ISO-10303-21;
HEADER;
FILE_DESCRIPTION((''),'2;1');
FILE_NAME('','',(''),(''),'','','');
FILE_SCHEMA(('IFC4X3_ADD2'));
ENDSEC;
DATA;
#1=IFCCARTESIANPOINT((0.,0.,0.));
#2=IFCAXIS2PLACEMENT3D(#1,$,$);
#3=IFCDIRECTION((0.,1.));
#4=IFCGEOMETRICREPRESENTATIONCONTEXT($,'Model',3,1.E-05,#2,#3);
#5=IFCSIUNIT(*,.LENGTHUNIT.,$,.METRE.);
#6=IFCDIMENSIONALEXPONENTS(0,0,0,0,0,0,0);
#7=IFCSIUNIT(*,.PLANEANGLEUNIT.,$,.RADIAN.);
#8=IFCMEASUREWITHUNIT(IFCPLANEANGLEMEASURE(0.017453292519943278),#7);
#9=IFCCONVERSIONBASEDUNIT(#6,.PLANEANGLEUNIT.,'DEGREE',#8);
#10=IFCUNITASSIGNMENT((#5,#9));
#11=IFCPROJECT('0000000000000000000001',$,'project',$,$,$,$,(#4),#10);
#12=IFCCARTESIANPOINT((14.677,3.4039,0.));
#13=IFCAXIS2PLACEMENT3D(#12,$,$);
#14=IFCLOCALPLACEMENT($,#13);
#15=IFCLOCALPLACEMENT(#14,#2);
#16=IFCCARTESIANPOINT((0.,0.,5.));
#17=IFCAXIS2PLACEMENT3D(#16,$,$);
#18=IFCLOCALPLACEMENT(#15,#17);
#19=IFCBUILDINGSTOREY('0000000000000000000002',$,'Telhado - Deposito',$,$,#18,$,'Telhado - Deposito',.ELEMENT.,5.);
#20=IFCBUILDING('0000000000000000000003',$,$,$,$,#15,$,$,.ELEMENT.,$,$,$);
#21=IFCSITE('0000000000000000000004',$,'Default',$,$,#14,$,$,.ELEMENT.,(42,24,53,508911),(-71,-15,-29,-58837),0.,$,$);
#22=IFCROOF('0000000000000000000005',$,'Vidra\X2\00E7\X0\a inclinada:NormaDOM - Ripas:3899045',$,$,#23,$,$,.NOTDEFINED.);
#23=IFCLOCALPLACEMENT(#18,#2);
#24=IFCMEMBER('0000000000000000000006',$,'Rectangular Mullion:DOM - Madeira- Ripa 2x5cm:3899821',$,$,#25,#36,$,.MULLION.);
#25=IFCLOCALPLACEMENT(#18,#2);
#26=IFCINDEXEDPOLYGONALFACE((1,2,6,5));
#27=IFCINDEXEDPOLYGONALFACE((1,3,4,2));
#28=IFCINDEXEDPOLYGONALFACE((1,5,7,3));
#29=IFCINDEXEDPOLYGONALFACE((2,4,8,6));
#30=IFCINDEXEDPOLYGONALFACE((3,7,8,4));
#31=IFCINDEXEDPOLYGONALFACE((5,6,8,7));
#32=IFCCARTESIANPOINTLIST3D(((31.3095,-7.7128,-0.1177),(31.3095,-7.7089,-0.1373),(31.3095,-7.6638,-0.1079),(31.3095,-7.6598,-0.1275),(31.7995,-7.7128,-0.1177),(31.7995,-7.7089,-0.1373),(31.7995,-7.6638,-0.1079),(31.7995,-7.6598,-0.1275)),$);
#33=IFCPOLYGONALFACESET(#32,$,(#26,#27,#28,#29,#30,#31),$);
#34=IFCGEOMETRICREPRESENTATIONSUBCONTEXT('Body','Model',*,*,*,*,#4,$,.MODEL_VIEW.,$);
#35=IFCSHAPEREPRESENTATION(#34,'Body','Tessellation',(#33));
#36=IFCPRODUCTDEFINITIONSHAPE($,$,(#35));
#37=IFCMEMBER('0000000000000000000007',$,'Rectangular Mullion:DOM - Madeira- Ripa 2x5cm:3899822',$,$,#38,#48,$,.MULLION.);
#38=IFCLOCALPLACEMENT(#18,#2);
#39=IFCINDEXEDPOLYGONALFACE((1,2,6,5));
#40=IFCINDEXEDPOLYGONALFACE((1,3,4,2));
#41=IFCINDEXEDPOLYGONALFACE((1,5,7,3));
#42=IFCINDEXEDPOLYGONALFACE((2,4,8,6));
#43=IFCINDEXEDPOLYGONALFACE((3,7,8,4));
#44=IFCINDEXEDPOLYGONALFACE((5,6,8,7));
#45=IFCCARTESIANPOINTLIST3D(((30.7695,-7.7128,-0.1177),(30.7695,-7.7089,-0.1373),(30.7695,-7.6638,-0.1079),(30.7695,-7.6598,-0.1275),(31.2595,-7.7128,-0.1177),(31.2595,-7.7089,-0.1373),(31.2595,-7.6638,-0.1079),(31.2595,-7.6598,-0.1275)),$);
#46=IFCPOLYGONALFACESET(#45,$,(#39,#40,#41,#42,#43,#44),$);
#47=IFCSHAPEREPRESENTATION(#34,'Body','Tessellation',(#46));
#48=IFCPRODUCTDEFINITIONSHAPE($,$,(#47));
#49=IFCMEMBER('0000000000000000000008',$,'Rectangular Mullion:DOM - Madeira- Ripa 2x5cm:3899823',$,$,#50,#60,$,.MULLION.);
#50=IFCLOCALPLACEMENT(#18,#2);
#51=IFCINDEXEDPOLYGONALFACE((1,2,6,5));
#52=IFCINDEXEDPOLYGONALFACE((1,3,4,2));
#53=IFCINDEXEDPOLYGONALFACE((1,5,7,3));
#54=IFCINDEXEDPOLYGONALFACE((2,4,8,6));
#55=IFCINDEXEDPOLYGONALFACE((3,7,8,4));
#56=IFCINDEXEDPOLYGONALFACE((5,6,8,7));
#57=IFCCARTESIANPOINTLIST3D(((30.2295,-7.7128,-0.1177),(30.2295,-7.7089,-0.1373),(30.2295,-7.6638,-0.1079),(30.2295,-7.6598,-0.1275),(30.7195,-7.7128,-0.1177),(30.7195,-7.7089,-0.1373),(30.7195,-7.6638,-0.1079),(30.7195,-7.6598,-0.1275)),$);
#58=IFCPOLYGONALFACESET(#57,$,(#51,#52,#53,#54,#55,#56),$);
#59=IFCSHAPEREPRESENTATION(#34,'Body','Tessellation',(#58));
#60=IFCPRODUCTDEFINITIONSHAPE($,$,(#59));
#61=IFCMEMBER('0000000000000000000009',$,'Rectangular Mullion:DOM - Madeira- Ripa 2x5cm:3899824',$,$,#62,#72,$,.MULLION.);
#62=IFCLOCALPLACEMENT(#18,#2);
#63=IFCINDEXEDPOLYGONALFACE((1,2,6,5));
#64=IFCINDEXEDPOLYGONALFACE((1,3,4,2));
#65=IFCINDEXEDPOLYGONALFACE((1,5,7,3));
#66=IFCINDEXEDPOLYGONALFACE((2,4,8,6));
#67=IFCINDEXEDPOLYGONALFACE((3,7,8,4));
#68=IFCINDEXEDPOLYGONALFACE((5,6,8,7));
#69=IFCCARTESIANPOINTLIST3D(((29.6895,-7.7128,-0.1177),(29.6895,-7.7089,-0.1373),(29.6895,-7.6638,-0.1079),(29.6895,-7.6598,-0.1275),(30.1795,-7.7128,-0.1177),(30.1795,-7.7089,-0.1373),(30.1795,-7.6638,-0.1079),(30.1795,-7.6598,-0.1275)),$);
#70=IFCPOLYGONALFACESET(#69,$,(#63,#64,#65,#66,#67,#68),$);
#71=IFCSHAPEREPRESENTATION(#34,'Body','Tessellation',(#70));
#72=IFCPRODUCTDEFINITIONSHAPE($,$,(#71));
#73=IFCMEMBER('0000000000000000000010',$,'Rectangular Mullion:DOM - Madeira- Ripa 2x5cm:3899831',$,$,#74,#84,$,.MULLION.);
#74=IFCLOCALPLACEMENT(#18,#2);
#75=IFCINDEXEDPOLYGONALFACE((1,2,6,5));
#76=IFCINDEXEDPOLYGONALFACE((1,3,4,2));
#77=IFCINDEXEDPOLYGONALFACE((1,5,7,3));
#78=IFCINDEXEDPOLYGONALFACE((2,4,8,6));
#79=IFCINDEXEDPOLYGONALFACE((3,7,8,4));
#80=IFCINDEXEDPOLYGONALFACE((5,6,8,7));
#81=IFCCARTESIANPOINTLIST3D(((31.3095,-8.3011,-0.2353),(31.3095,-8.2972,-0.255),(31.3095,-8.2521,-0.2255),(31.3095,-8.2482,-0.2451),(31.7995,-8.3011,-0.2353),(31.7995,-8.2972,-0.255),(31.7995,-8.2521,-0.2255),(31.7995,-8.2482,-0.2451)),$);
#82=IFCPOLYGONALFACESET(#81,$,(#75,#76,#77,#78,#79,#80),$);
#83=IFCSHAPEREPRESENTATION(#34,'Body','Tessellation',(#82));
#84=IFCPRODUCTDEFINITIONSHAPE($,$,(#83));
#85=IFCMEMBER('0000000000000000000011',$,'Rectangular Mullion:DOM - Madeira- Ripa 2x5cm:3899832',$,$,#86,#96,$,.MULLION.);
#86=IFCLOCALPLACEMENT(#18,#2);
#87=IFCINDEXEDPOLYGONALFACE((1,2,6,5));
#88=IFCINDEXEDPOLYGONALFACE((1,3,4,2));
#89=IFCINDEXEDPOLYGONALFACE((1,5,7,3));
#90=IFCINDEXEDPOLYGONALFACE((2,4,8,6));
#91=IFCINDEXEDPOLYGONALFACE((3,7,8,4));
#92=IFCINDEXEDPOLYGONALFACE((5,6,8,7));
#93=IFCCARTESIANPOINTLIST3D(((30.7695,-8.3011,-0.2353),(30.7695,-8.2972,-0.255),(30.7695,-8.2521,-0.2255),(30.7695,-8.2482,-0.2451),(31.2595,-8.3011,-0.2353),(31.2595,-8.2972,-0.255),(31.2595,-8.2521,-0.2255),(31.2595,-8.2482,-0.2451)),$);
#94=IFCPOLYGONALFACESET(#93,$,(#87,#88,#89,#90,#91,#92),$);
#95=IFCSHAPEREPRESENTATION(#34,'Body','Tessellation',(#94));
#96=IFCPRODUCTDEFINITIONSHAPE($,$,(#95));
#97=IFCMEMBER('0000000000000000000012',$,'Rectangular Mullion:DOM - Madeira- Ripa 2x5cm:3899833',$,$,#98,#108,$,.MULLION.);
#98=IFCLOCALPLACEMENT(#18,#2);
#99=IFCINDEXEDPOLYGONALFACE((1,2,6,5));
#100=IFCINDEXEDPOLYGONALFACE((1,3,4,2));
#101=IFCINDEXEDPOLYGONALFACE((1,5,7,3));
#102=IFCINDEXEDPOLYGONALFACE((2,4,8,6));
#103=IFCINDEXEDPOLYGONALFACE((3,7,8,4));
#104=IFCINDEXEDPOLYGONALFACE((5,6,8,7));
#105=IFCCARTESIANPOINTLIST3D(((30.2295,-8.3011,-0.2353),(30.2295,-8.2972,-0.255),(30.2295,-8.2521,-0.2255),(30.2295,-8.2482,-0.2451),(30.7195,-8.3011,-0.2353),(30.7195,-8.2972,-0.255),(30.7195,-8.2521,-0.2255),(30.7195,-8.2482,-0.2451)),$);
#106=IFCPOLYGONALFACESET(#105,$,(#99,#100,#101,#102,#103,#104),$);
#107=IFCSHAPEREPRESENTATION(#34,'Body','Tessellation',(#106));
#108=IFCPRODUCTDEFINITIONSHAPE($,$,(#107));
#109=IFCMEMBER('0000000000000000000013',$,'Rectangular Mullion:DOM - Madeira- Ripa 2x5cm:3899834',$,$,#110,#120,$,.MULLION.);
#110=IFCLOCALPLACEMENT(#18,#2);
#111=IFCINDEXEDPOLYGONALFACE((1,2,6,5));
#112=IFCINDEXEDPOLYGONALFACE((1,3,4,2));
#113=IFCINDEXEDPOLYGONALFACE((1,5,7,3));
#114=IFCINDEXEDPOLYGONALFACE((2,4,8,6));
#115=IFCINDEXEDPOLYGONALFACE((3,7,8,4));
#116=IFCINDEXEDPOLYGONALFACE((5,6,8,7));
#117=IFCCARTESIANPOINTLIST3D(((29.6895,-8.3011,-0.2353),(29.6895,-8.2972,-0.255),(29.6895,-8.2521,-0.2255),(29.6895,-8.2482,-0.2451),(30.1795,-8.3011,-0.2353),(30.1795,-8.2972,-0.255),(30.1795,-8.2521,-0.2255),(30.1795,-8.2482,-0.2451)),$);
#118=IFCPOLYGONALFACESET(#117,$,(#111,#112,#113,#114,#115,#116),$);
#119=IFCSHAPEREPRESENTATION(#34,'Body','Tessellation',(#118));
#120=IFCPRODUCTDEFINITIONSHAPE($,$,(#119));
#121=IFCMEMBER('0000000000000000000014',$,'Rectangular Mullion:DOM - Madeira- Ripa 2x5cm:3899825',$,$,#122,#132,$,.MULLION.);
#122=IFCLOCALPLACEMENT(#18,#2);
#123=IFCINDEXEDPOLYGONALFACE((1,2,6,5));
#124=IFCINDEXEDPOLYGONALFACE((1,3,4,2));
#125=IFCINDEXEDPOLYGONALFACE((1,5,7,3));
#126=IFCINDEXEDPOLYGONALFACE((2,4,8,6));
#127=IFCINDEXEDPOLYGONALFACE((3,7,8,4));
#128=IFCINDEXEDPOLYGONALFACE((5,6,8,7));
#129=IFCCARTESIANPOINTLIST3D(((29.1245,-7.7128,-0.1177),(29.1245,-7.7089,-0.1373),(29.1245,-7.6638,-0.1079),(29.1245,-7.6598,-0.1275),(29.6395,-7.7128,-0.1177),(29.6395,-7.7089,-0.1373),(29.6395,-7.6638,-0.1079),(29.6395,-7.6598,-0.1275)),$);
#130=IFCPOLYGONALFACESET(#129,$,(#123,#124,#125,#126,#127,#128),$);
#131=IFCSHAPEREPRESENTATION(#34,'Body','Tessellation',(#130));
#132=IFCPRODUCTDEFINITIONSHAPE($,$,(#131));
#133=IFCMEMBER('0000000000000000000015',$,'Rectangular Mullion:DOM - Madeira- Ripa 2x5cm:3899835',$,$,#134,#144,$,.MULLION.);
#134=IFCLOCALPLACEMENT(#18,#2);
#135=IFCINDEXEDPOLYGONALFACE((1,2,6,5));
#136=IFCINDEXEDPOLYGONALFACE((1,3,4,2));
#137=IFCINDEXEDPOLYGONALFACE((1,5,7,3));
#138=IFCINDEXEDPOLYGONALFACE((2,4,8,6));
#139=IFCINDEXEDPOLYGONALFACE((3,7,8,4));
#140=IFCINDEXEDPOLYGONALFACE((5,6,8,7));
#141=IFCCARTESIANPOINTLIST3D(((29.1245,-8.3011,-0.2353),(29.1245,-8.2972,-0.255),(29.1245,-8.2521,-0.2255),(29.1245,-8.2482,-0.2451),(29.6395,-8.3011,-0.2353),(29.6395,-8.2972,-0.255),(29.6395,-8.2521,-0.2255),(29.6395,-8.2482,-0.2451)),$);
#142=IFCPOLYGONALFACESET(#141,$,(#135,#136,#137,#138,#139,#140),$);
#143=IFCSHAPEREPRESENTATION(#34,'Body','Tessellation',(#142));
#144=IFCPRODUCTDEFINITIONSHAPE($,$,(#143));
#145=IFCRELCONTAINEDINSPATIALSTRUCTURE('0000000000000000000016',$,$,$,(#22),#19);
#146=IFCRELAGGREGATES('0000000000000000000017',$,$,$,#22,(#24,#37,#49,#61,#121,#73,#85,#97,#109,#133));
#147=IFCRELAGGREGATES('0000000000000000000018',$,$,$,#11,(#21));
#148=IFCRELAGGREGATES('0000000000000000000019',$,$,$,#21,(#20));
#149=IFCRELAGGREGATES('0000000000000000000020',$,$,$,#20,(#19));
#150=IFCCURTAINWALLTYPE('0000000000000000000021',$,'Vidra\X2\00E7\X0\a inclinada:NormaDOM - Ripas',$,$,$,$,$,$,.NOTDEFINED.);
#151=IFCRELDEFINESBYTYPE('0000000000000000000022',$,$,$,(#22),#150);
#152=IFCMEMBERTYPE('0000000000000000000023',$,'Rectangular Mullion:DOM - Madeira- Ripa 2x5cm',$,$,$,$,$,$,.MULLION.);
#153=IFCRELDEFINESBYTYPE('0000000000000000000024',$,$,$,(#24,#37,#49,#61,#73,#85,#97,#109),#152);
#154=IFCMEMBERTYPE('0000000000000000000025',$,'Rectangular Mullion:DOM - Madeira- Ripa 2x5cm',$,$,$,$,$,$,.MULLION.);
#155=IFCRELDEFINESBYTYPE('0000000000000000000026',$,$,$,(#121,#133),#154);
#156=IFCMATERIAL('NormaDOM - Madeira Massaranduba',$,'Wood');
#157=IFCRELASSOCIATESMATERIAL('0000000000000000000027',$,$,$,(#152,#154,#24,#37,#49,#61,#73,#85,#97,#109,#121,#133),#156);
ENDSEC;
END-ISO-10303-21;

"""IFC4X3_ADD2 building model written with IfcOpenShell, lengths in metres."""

from ifc_helpers import new_model, entity, si_unit, converted_unit, direction, frame, origin, origin_2d_with_axis, place, context, subcontext, project, spatial, rectangle, extrude, source, transform, mapped, material, material_profile, profile_set, profile_usage, type_object, type_shapes, element, aggregate, save


model = new_model("IFC4X3_ADD2")

# Units and contexts
model_context = context("Model", 3, precision=1e-05, world=origin(), true_north=direction((0.0, 1.0)))
body_context = subcontext(model_context, "Body", "Model", "MODEL_VIEW")
ifc_project = project(units=[si_unit("LENGTHUNIT", "METRE"), converted_unit("PLANEANGLEUNIT", "DEGREE", entity("IfcPlaneAngleMeasure", 0.017453292519943278), si_unit("PLANEANGLEUNIT", "RADIAN"), dimensions=[0, 0, 0, 0, 0, 0, 0])], contexts=[model_context])

# Site, building, storey
site_placement = place(None, frame((14.677, 3.4039, 0.0)))
site = spatial("IfcSite", under=ifc_project, at=site_placement, Name="Default", CompositionType="ELEMENT", RefLatitude=(42, 24, 53, 508911), RefLongitude=(-71, -15, -29, -58837), RefElevation=0.0)
building_placement = place(site_placement, origin())
building = spatial("IfcBuilding", under=site, at=building_placement, CompositionType="ELEMENT")
storey_placement = place(building_placement, frame((0.0, 0.0, 5.0)))
storey = spatial("IfcBuildingStorey", under=building, at=storey_placement, Name="Telhado - Deposito", LongName="Telhado - Deposito", CompositionType="ELEMENT", Elevation=5.0)

# Roof, members
curtain_wall_type = type_object("IfcCurtainWallType", Name="Vidraça inclinada:NormaDOM - Ripas", PredefinedType="NOTDEFINED")
roof_placement = place(storey_placement, frame((0.0, 0.0, -5.0)))
roof = element("IfcRoof", 1, at=roof_placement, inside=storey, type_object=curtain_wall_type, Name="Vidraça inclinada:NormaDOM - Ripas:3899045", PredefinedType="NOTDEFINED")
ifc_material = material(Name="NormaDOM - Madeira Massaranduba", Category="Wood")
ifc_material_profile_1 = material_profile(ifc_material, rectangle(XDim=0.05, YDim=0.02, at=origin_2d_with_axis()), Name="DOM - Madeira- Ripa 2x5cm")
ifc_profile_set_1 = profile_set([ifc_material_profile_1], Name="DOM - Madeira- Ripa 2x5cm")
ifc_profile_usage_1 = profile_usage(ifc_profile_set_1)
member_type_1 = type_object("IfcMemberType", Name="Rectangular Mullion:DOM - Madeira- Ripa 2x5cm", PredefinedType="MULLION", material=ifc_profile_set_1)
shared_shape_1 = source(origin(), body_context, "Body", "SweptSolid", [
    extrude(rectangle(XDim=0.05, YDim=0.02, at=origin_2d_with_axis()), frame((0.025, 0.01, -0.49), z_axis=(0.0, 0.0, 1.0), x_axis=(-1.0, 0.0, 0.0)), (0.0, 0.0, 1.0), 0.49),
])
type_shapes(member_type_1, [shared_shape_1])
member_1_placement = place(roof_placement, frame((31.7995, -7.6638, 4.8921), z_axis=(1.0, 0.0, 0.0), x_axis=(0.0, -0.980581, -0.196116)))
member_1 = element("IfcMember", 2, at=member_1_placement, type_object=member_type_1, material=ifc_profile_usage_1, Name="Rectangular Mullion:DOM - Madeira- Ripa 2x5cm:3899821", PredefinedType="MULLION", context=body_context, shape_type="MappedRepresentation", body=[
    mapped(shared_shape_1, transform((0.0, 0.0, 0.0), scale=1.0)),
])
member_2_placement = place(roof_placement, frame((31.2595, -7.6638, 4.8921), z_axis=(1.0, 0.0, 0.0), x_axis=(0.0, -0.980581, -0.196116)))
member_2 = element("IfcMember", 3, at=member_2_placement, type_object=member_type_1, material=ifc_profile_usage_1, Name="Rectangular Mullion:DOM - Madeira- Ripa 2x5cm:3899822", PredefinedType="MULLION", context=body_context, shape_type="MappedRepresentation", body=[
    mapped(shared_shape_1, transform((0.0, 0.0, 0.0), scale=1.0)),
])
member_3_placement = place(roof_placement, frame((30.7195, -7.6638, 4.8921), z_axis=(1.0, 0.0, 0.0), x_axis=(0.0, -0.980581, -0.196116)))
member_3 = element("IfcMember", 4, at=member_3_placement, type_object=member_type_1, material=ifc_profile_usage_1, Name="Rectangular Mullion:DOM - Madeira- Ripa 2x5cm:3899823", PredefinedType="MULLION", context=body_context, shape_type="MappedRepresentation", body=[
    mapped(shared_shape_1, transform((0.0, 0.0, 0.0), scale=1.0)),
])
member_4_placement = place(roof_placement, frame((30.1795, -7.6638, 4.8921), z_axis=(1.0, 0.0, 0.0), x_axis=(0.0, -0.980581, -0.196116)))
member_4 = element("IfcMember", 5, at=member_4_placement, type_object=member_type_1, material=ifc_profile_usage_1, Name="Rectangular Mullion:DOM - Madeira- Ripa 2x5cm:3899824", PredefinedType="MULLION", context=body_context, shape_type="MappedRepresentation", body=[
    mapped(shared_shape_1, transform((0.0, 0.0, 0.0), scale=1.0)),
])
member_5_placement = place(roof_placement, frame((31.7995, -8.2521, 4.7745), z_axis=(1.0, 0.0, 0.0), x_axis=(0.0, -0.980581, -0.196116)))
member_5 = element("IfcMember", 6, at=member_5_placement, type_object=member_type_1, material=ifc_profile_usage_1, Name="Rectangular Mullion:DOM - Madeira- Ripa 2x5cm:3899831", PredefinedType="MULLION", context=body_context, shape_type="MappedRepresentation", body=[
    mapped(shared_shape_1, transform((0.0, 0.0, 0.0), scale=1.0)),
])
member_6_placement = place(roof_placement, frame((31.2595, -8.2521, 4.7745), z_axis=(1.0, 0.0, 0.0), x_axis=(0.0, -0.980581, -0.196116)))
member_6 = element("IfcMember", 7, at=member_6_placement, type_object=member_type_1, material=ifc_profile_usage_1, Name="Rectangular Mullion:DOM - Madeira- Ripa 2x5cm:3899832", PredefinedType="MULLION", context=body_context, shape_type="MappedRepresentation", body=[
    mapped(shared_shape_1, transform((0.0, 0.0, 0.0), scale=1.0)),
])
member_7_placement = place(roof_placement, frame((30.7195, -8.2521, 4.7745), z_axis=(1.0, 0.0, 0.0), x_axis=(0.0, -0.980581, -0.196116)))
member_7 = element("IfcMember", 8, at=member_7_placement, type_object=member_type_1, material=ifc_profile_usage_1, Name="Rectangular Mullion:DOM - Madeira- Ripa 2x5cm:3899833", PredefinedType="MULLION", context=body_context, shape_type="MappedRepresentation", body=[
    mapped(shared_shape_1, transform((0.0, 0.0, 0.0), scale=1.0)),
])
member_8_placement = place(roof_placement, frame((30.1795, -8.2521, 4.7745), z_axis=(1.0, 0.0, 0.0), x_axis=(0.0, -0.980581, -0.196116)))
member_8 = element("IfcMember", 9, at=member_8_placement, type_object=member_type_1, material=ifc_profile_usage_1, Name="Rectangular Mullion:DOM - Madeira- Ripa 2x5cm:3899834", PredefinedType="MULLION", context=body_context, shape_type="MappedRepresentation", body=[
    mapped(shared_shape_1, transform((0.0, 0.0, 0.0), scale=1.0)),
])
member_type_2 = type_object("IfcMemberType", Name="Rectangular Mullion:DOM - Madeira- Ripa 2x5cm", PredefinedType="MULLION", material=ifc_profile_set_1)
shared_shape_2 = source(origin(), body_context, "Body", "SweptSolid", [
    extrude(rectangle(XDim=0.05, YDim=0.02, at=origin_2d_with_axis()), frame((0.025, 0.01, -0.515), z_axis=(0.0, 0.0, 1.0), x_axis=(-1.0, 0.0, 0.0)), (0.0, 0.0, 1.0), 0.515),
])
type_shapes(member_type_2, [shared_shape_2])
member_9_placement = place(roof_placement, frame((29.6395, -7.6638, 4.8921), z_axis=(1.0, 0.0, 0.0), x_axis=(0.0, -0.980581, -0.196116)))
member_9 = element("IfcMember", 10, at=member_9_placement, type_object=member_type_2, material=ifc_profile_usage_1, Name="Rectangular Mullion:DOM - Madeira- Ripa 2x5cm:3899825", PredefinedType="MULLION", context=body_context, shape_type="MappedRepresentation", body=[
    mapped(shared_shape_2, transform((0.0, 0.0, 0.0), scale=1.0)),
])
member_10_placement = place(roof_placement, frame((29.6395, -8.2521, 4.7745), z_axis=(1.0, 0.0, 0.0), x_axis=(0.0, -0.980581, -0.196116)))
member_10 = element("IfcMember", 11, at=member_10_placement, type_object=member_type_2, material=ifc_profile_usage_1, Name="Rectangular Mullion:DOM - Madeira- Ripa 2x5cm:3899835", PredefinedType="MULLION", context=body_context, shape_type="MappedRepresentation", body=[
    mapped(shared_shape_2, transform((0.0, 0.0, 0.0), scale=1.0)),
])
aggregate(roof, [member_1, member_2, member_3, member_4, member_9, member_5, member_6, member_7, member_8, member_10])

save(model, "model.ifc")
